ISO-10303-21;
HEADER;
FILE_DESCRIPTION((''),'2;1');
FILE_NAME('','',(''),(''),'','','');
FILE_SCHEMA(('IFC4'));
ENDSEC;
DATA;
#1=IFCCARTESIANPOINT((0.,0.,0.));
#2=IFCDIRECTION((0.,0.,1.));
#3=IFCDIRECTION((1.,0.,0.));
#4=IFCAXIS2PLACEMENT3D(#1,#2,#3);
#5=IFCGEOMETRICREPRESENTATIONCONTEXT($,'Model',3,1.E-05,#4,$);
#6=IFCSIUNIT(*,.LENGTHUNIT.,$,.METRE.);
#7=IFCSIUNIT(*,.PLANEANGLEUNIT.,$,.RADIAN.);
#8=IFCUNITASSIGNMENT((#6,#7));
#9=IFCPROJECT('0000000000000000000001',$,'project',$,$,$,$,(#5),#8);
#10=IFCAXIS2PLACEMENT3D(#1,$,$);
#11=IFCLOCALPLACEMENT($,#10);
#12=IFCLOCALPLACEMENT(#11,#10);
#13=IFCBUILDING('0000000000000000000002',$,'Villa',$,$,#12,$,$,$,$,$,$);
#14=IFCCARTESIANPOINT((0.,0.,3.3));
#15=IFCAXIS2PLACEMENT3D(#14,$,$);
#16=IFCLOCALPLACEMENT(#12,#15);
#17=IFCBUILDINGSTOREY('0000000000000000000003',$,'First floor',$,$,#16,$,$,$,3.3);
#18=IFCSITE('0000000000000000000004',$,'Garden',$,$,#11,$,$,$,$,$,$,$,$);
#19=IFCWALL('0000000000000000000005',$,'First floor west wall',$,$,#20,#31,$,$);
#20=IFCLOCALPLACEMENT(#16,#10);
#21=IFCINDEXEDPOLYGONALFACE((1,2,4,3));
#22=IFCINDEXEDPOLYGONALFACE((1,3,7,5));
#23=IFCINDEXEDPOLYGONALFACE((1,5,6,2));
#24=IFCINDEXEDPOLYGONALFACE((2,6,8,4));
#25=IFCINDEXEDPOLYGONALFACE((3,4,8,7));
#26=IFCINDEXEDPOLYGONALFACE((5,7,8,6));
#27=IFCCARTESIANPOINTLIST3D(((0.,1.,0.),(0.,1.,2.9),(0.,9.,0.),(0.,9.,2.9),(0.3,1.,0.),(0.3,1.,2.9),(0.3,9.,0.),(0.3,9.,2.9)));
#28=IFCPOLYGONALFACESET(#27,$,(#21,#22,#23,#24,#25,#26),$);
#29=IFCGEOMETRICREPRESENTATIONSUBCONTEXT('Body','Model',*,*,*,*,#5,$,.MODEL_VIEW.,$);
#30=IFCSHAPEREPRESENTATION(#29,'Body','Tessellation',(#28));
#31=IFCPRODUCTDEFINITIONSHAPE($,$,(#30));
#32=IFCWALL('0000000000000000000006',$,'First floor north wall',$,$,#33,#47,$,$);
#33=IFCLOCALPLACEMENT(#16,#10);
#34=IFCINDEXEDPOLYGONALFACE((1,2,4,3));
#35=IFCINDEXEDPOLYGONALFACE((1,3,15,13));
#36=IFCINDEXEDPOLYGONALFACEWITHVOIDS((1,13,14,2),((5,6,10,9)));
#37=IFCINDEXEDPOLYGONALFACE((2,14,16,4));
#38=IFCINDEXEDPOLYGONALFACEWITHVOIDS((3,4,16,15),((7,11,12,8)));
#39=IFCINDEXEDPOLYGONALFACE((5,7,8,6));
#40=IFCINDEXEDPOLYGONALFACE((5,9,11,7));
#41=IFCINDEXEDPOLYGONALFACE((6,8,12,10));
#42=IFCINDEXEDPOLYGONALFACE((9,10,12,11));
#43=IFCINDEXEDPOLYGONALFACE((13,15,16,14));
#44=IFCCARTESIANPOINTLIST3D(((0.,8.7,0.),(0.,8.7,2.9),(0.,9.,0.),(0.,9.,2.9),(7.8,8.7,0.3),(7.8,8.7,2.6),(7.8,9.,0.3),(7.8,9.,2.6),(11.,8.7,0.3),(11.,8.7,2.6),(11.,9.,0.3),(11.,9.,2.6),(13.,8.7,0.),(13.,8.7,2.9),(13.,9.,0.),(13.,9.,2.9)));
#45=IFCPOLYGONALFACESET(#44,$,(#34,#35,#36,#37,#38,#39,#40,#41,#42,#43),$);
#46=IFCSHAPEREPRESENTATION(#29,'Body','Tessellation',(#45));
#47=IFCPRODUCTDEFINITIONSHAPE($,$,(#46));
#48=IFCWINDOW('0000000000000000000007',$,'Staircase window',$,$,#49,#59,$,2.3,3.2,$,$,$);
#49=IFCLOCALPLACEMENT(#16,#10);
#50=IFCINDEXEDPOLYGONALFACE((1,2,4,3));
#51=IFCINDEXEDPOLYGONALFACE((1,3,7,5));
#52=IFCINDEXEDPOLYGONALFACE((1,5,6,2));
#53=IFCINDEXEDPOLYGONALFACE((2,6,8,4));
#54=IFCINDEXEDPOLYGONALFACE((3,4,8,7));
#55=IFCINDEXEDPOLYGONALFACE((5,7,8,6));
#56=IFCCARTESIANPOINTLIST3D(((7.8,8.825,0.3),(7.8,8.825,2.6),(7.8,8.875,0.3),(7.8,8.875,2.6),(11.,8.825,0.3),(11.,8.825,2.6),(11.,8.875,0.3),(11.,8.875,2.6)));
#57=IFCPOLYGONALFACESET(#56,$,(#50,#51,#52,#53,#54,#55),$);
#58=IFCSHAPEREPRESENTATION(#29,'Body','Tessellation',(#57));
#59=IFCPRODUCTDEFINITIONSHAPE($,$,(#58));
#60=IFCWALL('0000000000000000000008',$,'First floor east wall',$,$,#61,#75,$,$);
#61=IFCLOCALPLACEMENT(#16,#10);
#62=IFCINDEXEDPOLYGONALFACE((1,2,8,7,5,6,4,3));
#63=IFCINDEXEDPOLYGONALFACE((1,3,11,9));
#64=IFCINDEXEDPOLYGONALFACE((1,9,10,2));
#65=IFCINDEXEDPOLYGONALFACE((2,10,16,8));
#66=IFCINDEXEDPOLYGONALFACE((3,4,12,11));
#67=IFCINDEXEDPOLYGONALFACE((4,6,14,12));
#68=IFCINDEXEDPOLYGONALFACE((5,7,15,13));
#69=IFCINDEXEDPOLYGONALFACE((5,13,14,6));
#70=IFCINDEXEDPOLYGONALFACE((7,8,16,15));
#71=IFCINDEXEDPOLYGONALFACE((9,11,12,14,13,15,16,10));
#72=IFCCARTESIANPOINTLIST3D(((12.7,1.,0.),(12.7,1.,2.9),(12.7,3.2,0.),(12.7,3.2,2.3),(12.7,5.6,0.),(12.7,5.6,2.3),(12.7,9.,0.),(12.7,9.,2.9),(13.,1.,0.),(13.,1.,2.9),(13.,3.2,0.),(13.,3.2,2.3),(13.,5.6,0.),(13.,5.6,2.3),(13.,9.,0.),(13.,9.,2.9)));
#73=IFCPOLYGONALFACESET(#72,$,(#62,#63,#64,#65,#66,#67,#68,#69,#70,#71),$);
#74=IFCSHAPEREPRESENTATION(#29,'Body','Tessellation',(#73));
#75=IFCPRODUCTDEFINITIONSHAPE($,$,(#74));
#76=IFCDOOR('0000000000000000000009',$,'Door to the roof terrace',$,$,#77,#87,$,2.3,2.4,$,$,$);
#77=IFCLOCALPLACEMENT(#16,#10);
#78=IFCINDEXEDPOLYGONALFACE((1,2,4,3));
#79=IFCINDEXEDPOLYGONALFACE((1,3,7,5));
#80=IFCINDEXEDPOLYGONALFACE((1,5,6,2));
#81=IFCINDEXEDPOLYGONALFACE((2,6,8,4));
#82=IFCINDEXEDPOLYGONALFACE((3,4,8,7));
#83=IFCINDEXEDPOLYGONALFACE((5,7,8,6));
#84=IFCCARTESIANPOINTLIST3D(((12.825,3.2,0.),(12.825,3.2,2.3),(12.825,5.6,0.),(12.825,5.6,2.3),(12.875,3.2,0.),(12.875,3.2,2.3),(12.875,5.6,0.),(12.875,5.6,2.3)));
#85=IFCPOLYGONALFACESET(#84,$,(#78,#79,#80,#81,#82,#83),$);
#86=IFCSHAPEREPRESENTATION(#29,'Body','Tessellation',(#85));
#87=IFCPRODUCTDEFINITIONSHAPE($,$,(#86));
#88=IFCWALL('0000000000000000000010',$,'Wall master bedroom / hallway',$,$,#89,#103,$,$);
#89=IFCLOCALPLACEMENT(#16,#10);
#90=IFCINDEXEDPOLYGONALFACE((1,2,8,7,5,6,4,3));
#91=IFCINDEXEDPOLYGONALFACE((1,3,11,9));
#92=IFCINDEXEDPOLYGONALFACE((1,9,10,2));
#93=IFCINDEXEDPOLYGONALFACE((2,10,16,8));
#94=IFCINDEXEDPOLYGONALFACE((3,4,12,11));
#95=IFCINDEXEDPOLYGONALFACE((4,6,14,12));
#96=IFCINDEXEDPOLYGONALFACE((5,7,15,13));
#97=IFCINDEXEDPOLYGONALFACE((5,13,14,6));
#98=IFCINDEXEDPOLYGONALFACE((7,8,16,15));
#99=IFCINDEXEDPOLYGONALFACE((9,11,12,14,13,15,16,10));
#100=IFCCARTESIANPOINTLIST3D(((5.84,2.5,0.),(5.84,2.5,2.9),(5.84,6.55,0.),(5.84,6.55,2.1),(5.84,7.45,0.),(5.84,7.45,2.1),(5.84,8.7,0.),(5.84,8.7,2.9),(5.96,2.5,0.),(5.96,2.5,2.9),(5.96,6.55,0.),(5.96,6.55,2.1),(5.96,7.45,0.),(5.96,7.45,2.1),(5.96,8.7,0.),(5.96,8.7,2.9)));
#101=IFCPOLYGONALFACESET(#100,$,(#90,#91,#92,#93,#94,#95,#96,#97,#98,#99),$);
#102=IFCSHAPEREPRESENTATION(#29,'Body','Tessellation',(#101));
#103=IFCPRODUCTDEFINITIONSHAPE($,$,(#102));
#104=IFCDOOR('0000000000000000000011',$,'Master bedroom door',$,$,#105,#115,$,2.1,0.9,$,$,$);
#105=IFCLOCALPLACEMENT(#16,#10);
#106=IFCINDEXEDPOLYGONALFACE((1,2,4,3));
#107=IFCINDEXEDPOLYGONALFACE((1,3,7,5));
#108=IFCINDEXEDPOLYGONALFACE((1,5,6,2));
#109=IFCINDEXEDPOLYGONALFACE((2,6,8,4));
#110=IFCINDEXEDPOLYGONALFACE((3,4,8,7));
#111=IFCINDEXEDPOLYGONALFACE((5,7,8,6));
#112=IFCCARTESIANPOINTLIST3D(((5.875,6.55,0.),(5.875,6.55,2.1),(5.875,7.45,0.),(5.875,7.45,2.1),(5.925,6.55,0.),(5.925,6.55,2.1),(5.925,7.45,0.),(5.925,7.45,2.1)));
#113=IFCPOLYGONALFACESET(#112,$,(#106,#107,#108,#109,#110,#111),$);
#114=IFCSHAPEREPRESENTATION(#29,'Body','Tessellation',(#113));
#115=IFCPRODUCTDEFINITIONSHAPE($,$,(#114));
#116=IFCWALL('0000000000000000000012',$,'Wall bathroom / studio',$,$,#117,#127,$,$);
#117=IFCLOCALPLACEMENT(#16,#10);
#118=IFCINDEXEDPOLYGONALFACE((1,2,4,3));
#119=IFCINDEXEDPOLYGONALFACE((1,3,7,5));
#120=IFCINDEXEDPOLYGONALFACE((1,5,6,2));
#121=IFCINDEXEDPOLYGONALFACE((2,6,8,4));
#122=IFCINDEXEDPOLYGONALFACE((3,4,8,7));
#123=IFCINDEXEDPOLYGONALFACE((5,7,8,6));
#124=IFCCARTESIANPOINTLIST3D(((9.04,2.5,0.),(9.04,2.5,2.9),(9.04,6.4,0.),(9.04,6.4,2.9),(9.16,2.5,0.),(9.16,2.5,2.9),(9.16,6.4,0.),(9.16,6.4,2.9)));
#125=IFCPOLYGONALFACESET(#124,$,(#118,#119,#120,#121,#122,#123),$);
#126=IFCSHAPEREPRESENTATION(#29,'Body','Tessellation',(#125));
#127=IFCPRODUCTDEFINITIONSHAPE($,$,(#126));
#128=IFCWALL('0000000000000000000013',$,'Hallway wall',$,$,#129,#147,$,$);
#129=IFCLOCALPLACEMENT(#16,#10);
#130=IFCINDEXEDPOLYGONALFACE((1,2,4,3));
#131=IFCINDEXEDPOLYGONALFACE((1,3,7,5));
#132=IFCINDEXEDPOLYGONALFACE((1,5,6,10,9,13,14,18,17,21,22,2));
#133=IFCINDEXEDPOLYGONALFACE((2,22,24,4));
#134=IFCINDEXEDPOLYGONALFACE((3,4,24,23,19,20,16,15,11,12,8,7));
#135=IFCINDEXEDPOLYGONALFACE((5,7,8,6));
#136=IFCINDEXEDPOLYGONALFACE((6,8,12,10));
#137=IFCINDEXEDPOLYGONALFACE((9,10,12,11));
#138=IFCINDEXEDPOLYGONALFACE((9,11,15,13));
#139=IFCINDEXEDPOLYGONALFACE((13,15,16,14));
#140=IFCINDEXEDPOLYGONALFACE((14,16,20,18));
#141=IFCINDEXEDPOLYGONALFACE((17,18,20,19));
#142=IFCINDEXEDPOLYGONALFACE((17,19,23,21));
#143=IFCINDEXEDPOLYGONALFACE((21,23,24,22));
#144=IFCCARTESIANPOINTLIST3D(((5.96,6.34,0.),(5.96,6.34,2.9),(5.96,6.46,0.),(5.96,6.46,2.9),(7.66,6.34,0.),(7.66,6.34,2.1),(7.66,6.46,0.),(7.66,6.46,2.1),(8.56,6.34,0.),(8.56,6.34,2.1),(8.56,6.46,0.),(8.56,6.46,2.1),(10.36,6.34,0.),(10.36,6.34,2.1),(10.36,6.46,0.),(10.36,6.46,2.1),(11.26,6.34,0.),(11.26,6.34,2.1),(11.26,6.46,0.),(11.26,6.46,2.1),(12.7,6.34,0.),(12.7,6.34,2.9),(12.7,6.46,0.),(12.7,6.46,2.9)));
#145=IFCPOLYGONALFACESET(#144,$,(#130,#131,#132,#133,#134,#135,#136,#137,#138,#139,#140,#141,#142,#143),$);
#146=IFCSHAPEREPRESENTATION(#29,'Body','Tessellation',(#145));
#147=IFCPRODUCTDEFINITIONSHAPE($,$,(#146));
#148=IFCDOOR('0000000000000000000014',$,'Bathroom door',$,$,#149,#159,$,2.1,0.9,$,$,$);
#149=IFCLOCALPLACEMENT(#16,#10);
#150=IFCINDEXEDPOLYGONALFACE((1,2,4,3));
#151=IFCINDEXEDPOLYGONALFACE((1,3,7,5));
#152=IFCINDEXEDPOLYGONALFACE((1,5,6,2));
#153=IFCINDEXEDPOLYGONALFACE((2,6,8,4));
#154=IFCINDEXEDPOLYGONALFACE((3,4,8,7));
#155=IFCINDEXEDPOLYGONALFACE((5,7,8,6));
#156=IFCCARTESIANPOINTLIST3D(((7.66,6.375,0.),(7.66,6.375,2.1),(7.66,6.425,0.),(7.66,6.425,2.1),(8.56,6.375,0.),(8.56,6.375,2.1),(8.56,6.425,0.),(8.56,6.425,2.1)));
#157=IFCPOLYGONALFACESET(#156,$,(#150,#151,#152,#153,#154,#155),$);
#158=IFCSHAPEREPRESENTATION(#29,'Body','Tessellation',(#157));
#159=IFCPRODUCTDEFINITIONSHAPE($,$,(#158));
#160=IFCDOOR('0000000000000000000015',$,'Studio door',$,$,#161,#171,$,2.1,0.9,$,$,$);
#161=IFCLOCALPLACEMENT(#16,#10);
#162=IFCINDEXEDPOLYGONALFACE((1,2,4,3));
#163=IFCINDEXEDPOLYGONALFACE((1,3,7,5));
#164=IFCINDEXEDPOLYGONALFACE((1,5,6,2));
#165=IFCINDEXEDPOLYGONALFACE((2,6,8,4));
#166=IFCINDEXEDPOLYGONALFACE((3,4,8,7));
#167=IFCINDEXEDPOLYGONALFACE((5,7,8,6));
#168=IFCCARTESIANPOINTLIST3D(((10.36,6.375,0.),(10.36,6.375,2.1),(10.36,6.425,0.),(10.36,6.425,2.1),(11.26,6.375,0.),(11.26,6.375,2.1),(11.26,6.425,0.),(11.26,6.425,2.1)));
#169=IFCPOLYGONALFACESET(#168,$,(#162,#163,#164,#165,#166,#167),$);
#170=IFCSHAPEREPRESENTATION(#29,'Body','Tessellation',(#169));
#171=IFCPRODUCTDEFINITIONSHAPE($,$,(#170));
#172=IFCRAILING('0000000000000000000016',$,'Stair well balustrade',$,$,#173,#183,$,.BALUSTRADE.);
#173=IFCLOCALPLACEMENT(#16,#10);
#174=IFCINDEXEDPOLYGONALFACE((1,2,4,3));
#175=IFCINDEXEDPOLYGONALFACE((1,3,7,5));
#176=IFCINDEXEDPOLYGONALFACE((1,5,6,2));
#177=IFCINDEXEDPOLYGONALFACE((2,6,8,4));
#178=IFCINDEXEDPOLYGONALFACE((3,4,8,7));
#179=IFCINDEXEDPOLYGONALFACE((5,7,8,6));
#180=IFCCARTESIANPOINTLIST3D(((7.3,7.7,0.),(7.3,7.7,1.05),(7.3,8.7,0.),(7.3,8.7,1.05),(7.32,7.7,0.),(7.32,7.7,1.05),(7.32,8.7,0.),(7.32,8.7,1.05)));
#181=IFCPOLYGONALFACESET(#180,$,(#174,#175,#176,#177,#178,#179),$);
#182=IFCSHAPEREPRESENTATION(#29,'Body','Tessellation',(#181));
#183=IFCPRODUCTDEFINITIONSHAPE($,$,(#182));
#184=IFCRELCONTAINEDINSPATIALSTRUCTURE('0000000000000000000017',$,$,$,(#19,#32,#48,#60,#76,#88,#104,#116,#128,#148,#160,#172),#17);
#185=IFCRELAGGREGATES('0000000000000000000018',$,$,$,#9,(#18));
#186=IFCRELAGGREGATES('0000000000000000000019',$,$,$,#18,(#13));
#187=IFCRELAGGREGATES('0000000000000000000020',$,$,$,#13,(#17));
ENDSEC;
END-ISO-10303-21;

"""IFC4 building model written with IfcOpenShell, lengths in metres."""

from ifc_helpers import new_model, si_unit, frame, frame_2d, origin, origin_with_axes, place, context, subcontext, project, spatial, rectangle, extrude, element, fill, save


model = new_model("IFC4")

# Units and contexts
model_context = context("Model", 3, precision=1e-05, world=origin_with_axes())
body_context = subcontext(model_context, "Body", "Model", "MODEL_VIEW")
ifc_project = project(units=[si_unit("LENGTHUNIT", "METRE"), si_unit("PLANEANGLEUNIT", "RADIAN")], contexts=[model_context])

# Site, building, storey
site_placement = place(None, origin())
site = spatial("IfcSite", under=ifc_project, at=site_placement, Name="Garden")
building_placement = place(site_placement, origin())
building = spatial("IfcBuilding", under=site, at=building_placement, Name="Villa")
storey_placement = place(building_placement, frame((0.0, 0.0, 3.3)))
storey = spatial("IfcBuildingStorey", under=building, at=storey_placement, Name="First floor", Elevation=3.3)

# Wall
wall_1_placement = place(storey_placement, frame((0.15, 1.0, 0.0), x_axis=(0.0, 1.0, 0.0)))
element("IfcWall", 1, at=wall_1_placement, inside=storey, Name="First floor west wall", context=body_context, shape_type="SweptSolid", body=[
    extrude(rectangle(XDim=8.0, YDim=0.3, at=frame_2d((4.0, 0.0))), origin(), (0.0, 0.0, 1.0), 2.9),
])

# Wall, opening, window
wall_2_placement = place(storey_placement, frame((13.0, 8.85, 0.0), x_axis=(-1.0, 0.0, 0.0)))
wall_2 = element("IfcWall", 2, at=wall_2_placement, inside=storey, Name="First floor north wall", context=body_context, shape_type="SweptSolid", body=[
    extrude(rectangle(XDim=13.0, YDim=0.3, at=frame_2d((6.5, 0.0))), origin(), (0.0, 0.0, 1.0), 2.9),
])
opening_1_placement = place(wall_2_placement, frame((2.0, 0.0, 0.3)))
opening_1 = element("IfcOpeningElement", 3, at=opening_1_placement, cuts=wall_2, context=body_context, shape_type="SweptSolid", body=[
    extrude(rectangle(XDim=3.2, YDim=0.4, at=frame_2d((1.6, 0.0))), origin(), (0.0, 0.0, 1.0), 2.3),
])
window_placement = place(opening_1_placement, origin())
window = element("IfcWindow", 4, at=window_placement, inside=storey, Name="Staircase window", OverallHeight=2.3, OverallWidth=3.2, context=body_context, shape_type="SweptSolid", body=[
    extrude(rectangle(XDim=3.2, YDim=0.05, at=frame_2d((1.6, 0.0))), origin(), (0.0, 0.0, 1.0), 2.3),
])
fill(opening_1, window)

# Walls, openings, doors
wall_3_placement = place(storey_placement, frame((12.85, 1.0, 0.0), x_axis=(0.0, 1.0, 0.0)))
wall_3 = element("IfcWall", 5, at=wall_3_placement, inside=storey, Name="First floor east wall", context=body_context, shape_type="SweptSolid", body=[
    extrude(rectangle(XDim=8.0, YDim=0.3, at=frame_2d((4.0, 0.0))), origin(), (0.0, 0.0, 1.0), 2.9),
])
opening_2_placement = place(wall_3_placement, frame((2.2, 0.0, 0.0)))
opening_2 = element("IfcOpeningElement", 6, at=opening_2_placement, cuts=wall_3, context=body_context, shape_type="SweptSolid", body=[
    extrude(rectangle(XDim=2.4, YDim=0.4, at=frame_2d((1.2, 0.0))), origin(), (0.0, 0.0, 1.0), 2.3),
])
door_1_placement = place(opening_2_placement, origin())
door_1 = element("IfcDoor", 7, at=door_1_placement, inside=storey, Name="Door to the roof terrace", OverallHeight=2.3, OverallWidth=2.4, context=body_context, shape_type="SweptSolid", body=[
    extrude(rectangle(XDim=2.4, YDim=0.05, at=frame_2d((1.2, 0.0))), origin(), (0.0, 0.0, 1.0), 2.3),
])
fill(opening_2, door_1)
wall_4_placement = place(storey_placement, frame((5.9, 2.5, 0.0), x_axis=(0.0, 1.0, 0.0)))
wall_4 = element("IfcWall", 8, at=wall_4_placement, inside=storey, Name="Wall master bedroom / hallway", context=body_context, shape_type="SweptSolid", body=[
    extrude(rectangle(XDim=6.2, YDim=0.12, at=frame_2d((3.1, 0.0))), origin(), (0.0, 0.0, 1.0), 2.9),
])
opening_3_placement = place(wall_4_placement, frame((4.05, 0.0, 0.0)))
opening_3 = element("IfcOpeningElement", 9, at=opening_3_placement, cuts=wall_4, context=body_context, shape_type="SweptSolid", body=[
    extrude(rectangle(XDim=0.9, YDim=0.22, at=frame_2d((0.45, 0.0))), origin(), (0.0, 0.0, 1.0), 2.1),
])
door_2_placement = place(opening_3_placement, origin())
door_2 = element("IfcDoor", 10, at=door_2_placement, inside=storey, Name="Master bedroom door", OverallHeight=2.1, OverallWidth=0.9, context=body_context, shape_type="SweptSolid", body=[
    extrude(rectangle(XDim=0.9, YDim=0.05, at=frame_2d((0.45, 0.0))), origin(), (0.0, 0.0, 1.0), 2.1),
])
fill(opening_3, door_2)

# Wall
wall_5_placement = place(storey_placement, frame((9.1, 2.5, 0.0), x_axis=(0.0, 1.0, 0.0)))
element("IfcWall", 11, at=wall_5_placement, inside=storey, Name="Wall bathroom / studio", context=body_context, shape_type="SweptSolid", body=[
    extrude(rectangle(XDim=3.9, YDim=0.12, at=frame_2d((1.95, 0.0))), origin(), (0.0, 0.0, 1.0), 2.9),
])

# Wall, openings, doors
wall_6_placement = place(storey_placement, frame((5.96, 6.4, 0.0)))
wall_6 = element("IfcWall", 12, at=wall_6_placement, inside=storey, Name="Hallway wall", context=body_context, shape_type="SweptSolid", body=[
    extrude(rectangle(XDim=6.74, YDim=0.12, at=frame_2d((3.37, 0.0))), origin(), (0.0, 0.0, 1.0), 2.9),
])
opening_4_placement = place(wall_6_placement, frame((1.7, 0.0, 0.0)))
opening_4 = element("IfcOpeningElement", 13, at=opening_4_placement, cuts=wall_6, context=body_context, shape_type="SweptSolid", body=[
    extrude(rectangle(XDim=0.9, YDim=0.22, at=frame_2d((0.45, 0.0))), origin(), (0.0, 0.0, 1.0), 2.1),
])
opening_5_placement = place(wall_6_placement, frame((4.4, 0.0, 0.0)))
opening_5 = element("IfcOpeningElement", 14, at=opening_5_placement, cuts=wall_6, context=body_context, shape_type="SweptSolid", body=[
    extrude(rectangle(XDim=0.9, YDim=0.22, at=frame_2d((0.45, 0.0))), origin(), (0.0, 0.0, 1.0), 2.1),
])
door_3_placement = place(opening_4_placement, origin())
door_3 = element("IfcDoor", 15, at=door_3_placement, inside=storey, Name="Bathroom door", OverallHeight=2.1, OverallWidth=0.9, context=body_context, shape_type="SweptSolid", body=[
    extrude(rectangle(XDim=0.9, YDim=0.05, at=frame_2d((0.45, 0.0))), origin(), (0.0, 0.0, 1.0), 2.1),
])
fill(opening_4, door_3)
door_4_placement = place(opening_5_placement, origin())
door_4 = element("IfcDoor", 16, at=door_4_placement, inside=storey, Name="Studio door", OverallHeight=2.1, OverallWidth=0.9, context=body_context, shape_type="SweptSolid", body=[
    extrude(rectangle(XDim=0.9, YDim=0.05, at=frame_2d((0.45, 0.0))), origin(), (0.0, 0.0, 1.0), 2.1),
])
fill(opening_5, door_4)

# Railing
railing_placement = place(storey_placement, origin())
element("IfcRailing", 17, at=railing_placement, inside=storey, Name="Stair well balustrade", PredefinedType="BALUSTRADE", context=body_context, shape_type="SweptSolid", body=[
    extrude(rectangle(XDim=0.02, YDim=1.0, at=frame_2d((0.01, 0.5))), frame((7.3, 7.7, 0.0)), (0.0, 0.0, 1.0), 1.05),
])

save(model, "model.ifc")
